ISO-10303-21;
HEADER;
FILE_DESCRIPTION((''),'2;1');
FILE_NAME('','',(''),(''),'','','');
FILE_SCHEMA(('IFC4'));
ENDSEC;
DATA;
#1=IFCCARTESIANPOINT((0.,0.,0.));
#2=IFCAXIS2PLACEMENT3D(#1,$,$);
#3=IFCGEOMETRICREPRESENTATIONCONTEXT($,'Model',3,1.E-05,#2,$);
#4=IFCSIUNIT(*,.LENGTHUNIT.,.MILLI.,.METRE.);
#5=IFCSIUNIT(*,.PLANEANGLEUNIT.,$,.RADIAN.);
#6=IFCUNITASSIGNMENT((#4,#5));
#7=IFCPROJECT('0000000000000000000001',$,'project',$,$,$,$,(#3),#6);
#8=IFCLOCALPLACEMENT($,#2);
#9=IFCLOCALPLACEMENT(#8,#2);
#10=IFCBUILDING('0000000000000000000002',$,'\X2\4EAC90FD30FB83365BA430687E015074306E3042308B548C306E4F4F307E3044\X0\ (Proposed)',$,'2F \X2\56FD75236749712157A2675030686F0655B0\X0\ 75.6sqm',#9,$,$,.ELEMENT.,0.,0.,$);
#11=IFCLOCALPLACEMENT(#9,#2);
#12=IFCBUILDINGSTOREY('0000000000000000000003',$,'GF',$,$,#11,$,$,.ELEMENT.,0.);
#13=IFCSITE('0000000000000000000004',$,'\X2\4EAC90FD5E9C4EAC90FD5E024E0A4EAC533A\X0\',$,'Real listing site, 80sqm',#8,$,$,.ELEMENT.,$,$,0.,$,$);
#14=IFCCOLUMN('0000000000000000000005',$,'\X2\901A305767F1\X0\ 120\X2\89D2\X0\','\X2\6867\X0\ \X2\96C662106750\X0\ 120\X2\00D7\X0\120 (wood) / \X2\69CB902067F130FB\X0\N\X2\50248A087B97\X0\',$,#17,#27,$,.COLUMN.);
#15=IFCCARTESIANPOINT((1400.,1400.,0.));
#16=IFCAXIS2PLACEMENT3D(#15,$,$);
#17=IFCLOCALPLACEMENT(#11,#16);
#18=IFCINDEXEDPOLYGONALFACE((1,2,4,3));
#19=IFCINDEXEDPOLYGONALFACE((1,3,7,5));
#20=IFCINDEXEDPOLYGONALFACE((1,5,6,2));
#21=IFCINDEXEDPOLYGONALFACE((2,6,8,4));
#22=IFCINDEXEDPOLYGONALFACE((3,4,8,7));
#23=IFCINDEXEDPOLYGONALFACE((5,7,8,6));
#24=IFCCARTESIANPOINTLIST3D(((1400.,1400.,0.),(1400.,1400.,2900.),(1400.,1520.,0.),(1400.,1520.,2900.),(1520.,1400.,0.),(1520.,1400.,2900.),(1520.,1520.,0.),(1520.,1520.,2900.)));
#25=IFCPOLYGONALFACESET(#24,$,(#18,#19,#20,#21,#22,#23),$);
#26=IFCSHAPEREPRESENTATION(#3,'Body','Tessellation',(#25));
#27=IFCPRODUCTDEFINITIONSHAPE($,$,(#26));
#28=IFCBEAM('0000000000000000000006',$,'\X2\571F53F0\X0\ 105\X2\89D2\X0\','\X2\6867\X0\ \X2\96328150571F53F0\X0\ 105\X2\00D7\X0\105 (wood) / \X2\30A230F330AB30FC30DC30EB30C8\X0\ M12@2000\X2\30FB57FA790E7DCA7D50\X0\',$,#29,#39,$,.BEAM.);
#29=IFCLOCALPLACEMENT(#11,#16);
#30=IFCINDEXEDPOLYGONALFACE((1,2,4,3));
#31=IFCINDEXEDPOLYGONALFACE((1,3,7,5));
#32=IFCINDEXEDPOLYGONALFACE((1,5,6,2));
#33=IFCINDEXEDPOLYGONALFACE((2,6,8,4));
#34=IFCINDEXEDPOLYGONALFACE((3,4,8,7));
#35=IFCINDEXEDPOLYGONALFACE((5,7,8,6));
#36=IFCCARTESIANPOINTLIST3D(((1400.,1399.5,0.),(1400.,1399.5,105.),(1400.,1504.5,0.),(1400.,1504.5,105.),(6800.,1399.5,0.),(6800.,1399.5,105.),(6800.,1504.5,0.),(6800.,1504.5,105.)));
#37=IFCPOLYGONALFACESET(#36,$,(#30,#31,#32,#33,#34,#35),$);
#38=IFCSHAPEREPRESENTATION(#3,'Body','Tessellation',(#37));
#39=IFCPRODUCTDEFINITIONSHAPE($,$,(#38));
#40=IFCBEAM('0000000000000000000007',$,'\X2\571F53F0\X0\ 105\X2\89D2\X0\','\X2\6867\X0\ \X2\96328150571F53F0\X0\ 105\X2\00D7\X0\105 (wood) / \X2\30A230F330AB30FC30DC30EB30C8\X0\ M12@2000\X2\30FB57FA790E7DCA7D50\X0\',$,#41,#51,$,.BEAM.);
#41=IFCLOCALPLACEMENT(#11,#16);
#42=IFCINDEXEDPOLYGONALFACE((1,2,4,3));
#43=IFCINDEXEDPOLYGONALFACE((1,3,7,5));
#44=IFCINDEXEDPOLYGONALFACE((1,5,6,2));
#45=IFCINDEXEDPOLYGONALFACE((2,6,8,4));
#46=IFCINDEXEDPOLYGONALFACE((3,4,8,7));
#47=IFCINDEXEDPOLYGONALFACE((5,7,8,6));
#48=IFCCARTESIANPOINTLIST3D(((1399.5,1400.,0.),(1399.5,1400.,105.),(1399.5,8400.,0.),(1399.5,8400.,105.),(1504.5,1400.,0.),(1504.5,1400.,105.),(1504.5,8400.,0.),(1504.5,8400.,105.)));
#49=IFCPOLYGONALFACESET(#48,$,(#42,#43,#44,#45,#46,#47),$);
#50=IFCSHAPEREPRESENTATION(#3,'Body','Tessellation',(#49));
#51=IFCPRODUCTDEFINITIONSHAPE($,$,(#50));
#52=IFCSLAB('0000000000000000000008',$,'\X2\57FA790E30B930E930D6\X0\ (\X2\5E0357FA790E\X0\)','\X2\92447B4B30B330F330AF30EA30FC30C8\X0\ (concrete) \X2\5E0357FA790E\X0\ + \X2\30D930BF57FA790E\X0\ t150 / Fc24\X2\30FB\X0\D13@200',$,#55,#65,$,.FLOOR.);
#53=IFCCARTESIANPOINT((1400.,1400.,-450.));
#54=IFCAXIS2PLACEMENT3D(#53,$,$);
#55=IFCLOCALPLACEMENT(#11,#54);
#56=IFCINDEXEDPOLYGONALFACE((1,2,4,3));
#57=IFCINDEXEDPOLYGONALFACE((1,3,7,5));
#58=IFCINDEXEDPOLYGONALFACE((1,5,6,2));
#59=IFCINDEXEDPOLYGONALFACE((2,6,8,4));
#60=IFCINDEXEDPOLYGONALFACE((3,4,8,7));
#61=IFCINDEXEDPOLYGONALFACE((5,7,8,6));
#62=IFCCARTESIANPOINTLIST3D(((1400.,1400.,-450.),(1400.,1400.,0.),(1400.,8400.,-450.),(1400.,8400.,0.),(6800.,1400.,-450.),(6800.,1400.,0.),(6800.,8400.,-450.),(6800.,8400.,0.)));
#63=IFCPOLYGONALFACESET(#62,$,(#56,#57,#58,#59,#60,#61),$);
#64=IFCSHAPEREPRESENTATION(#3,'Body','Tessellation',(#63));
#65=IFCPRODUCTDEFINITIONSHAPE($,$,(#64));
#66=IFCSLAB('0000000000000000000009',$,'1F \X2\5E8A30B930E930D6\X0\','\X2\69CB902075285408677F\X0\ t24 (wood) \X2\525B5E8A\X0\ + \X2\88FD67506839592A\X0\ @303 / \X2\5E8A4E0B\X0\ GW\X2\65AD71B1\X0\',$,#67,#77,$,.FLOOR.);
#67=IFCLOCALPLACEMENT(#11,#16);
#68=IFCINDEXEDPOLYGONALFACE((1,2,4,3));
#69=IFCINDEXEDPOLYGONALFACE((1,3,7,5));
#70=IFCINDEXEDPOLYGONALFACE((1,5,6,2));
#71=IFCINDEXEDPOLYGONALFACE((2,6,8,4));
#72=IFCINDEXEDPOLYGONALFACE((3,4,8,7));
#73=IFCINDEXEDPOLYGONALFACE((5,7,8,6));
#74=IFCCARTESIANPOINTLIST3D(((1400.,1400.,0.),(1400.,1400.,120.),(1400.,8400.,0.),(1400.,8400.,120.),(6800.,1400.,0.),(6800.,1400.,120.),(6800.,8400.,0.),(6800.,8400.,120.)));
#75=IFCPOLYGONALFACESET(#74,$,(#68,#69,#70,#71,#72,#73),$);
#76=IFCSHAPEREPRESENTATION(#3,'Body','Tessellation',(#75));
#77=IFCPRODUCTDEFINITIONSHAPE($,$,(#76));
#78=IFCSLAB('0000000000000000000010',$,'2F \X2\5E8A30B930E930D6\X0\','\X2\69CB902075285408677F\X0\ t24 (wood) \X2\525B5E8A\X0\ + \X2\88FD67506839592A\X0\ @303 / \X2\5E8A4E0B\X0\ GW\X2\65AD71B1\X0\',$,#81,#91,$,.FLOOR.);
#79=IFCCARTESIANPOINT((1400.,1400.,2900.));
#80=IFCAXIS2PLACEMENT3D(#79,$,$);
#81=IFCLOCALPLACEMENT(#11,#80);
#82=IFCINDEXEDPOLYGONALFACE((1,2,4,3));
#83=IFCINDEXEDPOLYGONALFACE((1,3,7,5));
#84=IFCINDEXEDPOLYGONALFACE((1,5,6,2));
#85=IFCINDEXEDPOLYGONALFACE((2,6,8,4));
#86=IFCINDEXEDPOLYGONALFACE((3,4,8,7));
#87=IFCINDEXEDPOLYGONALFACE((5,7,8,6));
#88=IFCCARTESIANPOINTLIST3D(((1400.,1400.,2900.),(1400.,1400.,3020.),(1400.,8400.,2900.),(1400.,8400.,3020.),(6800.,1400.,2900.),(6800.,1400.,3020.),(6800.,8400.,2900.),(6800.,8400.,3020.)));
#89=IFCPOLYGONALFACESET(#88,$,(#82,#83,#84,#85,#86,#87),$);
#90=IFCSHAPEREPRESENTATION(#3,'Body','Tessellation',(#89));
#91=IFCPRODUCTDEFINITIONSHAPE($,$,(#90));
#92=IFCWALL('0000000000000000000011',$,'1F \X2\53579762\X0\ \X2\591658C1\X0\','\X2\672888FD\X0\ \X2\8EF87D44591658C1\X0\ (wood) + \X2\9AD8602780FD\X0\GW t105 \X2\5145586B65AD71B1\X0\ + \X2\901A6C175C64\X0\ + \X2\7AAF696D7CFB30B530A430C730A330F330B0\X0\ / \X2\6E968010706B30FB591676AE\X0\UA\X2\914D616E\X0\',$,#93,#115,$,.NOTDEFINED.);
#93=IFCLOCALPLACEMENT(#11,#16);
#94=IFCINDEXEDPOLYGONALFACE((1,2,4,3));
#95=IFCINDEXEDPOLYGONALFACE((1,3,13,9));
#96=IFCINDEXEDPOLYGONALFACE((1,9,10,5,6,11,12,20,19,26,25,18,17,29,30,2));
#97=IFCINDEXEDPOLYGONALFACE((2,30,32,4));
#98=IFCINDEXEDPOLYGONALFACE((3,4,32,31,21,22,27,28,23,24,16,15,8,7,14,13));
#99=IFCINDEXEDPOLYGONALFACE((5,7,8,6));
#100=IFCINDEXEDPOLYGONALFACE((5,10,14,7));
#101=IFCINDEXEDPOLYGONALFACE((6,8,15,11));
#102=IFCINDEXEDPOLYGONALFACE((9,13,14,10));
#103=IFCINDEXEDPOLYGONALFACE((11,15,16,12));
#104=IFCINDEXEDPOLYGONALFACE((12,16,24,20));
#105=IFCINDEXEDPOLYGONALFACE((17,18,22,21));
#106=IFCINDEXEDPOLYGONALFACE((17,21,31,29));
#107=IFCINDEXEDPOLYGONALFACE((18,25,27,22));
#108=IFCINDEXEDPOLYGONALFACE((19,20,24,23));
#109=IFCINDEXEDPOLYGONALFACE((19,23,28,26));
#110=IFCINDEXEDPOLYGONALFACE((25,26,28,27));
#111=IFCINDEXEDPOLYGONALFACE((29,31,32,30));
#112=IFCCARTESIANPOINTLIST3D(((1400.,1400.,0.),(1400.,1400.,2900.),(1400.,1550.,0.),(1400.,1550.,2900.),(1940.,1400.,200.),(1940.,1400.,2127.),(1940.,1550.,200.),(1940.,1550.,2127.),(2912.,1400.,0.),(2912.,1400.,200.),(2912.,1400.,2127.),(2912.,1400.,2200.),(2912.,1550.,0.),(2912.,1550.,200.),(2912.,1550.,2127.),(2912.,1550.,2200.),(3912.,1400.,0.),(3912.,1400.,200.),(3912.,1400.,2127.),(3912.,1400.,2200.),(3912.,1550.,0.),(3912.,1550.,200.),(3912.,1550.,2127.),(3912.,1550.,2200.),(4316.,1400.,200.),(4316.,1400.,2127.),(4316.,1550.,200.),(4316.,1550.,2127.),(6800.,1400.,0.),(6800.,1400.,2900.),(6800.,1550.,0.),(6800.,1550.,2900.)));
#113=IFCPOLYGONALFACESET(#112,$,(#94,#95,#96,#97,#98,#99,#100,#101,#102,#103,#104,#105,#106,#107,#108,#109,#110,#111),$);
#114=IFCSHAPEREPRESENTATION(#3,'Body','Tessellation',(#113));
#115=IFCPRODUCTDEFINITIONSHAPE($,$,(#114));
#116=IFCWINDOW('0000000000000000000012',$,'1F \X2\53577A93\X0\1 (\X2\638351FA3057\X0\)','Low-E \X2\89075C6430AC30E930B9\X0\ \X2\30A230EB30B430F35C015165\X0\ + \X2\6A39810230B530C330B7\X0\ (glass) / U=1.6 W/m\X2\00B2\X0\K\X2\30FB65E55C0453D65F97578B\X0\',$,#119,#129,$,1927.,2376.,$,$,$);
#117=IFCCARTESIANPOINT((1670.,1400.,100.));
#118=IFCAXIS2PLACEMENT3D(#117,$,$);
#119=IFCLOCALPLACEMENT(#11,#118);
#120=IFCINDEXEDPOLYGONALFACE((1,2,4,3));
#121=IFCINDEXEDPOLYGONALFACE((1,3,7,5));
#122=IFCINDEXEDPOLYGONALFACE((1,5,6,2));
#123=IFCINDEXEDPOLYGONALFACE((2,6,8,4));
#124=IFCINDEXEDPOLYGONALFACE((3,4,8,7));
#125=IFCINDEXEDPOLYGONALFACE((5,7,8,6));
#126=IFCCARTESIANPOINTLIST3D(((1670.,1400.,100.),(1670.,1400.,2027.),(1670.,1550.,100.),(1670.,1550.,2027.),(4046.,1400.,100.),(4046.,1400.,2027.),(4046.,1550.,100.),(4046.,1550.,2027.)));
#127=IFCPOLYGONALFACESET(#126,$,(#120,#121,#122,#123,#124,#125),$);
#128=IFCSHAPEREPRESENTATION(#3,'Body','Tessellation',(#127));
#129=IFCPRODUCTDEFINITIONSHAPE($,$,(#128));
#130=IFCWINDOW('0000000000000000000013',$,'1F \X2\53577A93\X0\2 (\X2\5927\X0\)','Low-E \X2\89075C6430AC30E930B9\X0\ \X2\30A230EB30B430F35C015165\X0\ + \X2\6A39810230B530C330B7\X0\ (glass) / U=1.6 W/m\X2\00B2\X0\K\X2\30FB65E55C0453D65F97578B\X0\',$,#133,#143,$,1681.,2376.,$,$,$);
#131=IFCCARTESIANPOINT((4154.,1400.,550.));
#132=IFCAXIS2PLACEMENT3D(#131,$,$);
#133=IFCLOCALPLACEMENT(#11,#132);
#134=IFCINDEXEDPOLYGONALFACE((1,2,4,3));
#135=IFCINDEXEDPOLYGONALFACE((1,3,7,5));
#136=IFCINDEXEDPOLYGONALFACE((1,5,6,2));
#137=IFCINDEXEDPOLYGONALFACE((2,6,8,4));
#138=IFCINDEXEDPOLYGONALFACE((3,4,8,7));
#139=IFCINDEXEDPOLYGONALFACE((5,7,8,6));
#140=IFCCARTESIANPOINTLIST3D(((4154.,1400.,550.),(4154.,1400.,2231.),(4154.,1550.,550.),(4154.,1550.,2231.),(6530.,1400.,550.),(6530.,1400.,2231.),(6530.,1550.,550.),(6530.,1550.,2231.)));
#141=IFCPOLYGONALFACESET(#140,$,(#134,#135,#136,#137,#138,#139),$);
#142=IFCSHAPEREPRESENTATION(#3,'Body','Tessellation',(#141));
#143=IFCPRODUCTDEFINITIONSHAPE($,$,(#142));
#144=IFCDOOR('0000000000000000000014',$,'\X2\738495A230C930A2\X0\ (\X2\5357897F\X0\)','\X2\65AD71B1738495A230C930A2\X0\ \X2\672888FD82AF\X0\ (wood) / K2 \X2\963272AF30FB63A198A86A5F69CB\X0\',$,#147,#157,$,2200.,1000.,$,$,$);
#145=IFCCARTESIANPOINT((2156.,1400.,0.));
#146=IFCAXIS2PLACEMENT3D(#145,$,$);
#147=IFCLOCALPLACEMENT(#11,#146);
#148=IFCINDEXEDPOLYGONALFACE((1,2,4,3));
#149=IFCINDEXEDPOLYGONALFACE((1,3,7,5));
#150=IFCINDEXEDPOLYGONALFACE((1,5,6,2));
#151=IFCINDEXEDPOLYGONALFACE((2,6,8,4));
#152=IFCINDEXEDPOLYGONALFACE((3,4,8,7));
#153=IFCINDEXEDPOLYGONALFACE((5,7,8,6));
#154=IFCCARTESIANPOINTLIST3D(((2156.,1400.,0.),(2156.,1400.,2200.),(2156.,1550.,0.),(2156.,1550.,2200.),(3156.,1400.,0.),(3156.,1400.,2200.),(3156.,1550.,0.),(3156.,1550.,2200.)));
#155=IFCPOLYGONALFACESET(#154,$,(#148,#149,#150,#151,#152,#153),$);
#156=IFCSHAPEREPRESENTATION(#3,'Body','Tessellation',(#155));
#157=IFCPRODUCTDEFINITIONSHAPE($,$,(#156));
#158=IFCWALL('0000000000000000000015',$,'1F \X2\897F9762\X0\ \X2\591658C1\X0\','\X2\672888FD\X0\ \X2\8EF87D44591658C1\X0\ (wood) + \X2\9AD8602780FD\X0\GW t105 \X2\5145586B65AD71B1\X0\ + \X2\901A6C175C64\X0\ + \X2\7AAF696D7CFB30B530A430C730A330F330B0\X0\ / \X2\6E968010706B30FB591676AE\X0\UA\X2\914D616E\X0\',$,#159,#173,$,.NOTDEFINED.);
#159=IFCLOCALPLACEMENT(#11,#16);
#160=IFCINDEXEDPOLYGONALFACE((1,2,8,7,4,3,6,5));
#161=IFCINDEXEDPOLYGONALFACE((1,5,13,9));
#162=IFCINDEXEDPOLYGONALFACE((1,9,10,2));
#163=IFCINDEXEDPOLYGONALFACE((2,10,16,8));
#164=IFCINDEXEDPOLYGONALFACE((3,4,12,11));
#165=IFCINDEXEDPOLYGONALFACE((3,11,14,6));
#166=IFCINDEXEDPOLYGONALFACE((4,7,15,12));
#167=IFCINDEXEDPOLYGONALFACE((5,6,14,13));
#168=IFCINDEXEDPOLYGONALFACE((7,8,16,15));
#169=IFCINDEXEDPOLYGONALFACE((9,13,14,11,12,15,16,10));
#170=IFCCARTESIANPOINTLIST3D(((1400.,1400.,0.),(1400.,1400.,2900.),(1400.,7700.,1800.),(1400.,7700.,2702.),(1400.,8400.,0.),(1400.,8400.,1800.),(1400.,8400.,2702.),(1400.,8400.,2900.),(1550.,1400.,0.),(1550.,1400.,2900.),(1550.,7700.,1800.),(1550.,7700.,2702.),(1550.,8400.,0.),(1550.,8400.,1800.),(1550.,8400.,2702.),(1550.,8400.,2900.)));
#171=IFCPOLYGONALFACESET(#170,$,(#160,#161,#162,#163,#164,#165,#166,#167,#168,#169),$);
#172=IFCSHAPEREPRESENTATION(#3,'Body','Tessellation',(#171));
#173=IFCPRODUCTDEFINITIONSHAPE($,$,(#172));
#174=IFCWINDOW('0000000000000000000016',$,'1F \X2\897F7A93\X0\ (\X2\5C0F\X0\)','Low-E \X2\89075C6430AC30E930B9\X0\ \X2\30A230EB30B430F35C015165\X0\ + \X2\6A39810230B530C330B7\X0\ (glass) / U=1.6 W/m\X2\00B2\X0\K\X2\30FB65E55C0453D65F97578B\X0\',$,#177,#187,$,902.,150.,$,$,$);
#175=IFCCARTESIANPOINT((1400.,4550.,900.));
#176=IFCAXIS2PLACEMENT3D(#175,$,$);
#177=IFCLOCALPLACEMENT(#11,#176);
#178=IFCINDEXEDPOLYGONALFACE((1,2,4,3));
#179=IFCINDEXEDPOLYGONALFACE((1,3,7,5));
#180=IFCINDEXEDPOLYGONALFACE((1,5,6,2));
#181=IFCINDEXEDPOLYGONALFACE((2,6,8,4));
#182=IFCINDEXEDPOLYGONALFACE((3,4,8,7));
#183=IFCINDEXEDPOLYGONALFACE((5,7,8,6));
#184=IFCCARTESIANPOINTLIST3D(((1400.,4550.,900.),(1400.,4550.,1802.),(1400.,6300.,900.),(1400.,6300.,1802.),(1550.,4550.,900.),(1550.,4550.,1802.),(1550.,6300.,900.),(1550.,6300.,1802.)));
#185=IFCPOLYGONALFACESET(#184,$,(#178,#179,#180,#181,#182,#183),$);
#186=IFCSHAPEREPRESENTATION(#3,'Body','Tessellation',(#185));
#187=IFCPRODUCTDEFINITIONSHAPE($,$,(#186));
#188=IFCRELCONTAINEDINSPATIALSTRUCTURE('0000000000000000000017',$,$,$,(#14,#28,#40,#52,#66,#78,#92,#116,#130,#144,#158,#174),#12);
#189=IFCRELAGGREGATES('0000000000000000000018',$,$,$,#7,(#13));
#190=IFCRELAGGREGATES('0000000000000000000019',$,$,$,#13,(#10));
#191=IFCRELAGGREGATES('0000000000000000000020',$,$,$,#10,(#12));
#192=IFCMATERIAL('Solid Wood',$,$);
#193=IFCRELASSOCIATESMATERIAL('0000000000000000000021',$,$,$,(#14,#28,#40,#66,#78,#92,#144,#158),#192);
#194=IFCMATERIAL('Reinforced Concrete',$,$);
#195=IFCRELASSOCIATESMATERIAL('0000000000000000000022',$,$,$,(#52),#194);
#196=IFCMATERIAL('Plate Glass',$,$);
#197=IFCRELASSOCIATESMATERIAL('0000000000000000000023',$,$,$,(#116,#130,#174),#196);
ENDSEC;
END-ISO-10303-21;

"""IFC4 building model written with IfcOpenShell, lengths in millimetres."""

from ifc_helpers import new_model, si_unit, frame, frame_2d, origin, place, context, project, spatial, rectangle, extrude, material, element, fill, save


model = new_model("IFC4")

# Units and contexts
model_context = context("Model", 3, precision=1e-05, world=origin())
ifc_project = project(units=[si_unit("LENGTHUNIT", "METRE", prefix="MILLI"), si_unit("PLANEANGLEUNIT", "RADIAN")], contexts=[model_context])

# Site, building, storey
site_placement = place(None, origin())
site = spatial("IfcSite", under=ifc_project, at=site_placement, Name="京都府京都市上京区", ObjectType="Real listing site, 80sqm", CompositionType="ELEMENT", RefElevation=0.0)
building_placement = place(site_placement, origin())
building = spatial("IfcBuilding", under=site, at=building_placement, Name="京都・茶室と縁側のある和の住まい (Proposed)", ObjectType="2F 国産杉無垢材と漆喰 75.6sqm", CompositionType="ELEMENT", ElevationOfRefHeight=0.0, ElevationOfTerrain=0.0)
storey_placement = place(building_placement, origin())
storey = spatial("IfcBuildingStorey", under=building, at=storey_placement, Name="GF", CompositionType="ELEMENT", Elevation=0.0)

# Column
ifc_material_1 = material(Name="Solid Wood")
column_placement = place(storey_placement, frame((1400.0, 1400.0, 0.0)))
element("IfcColumn", 1, at=column_placement, inside=storey, material=ifc_material_1, Name="通し柱 120角", Description="桧 集成材 120×120 (wood) / 構造柱・N値計算", PredefinedType="COLUMN", context=model_context, shape_type="SweptSolid", body=[
    extrude(rectangle(XDim=120.0, YDim=120.0, at=frame_2d((60.0, 60.0))), frame((1400.0, 1400.0, 0.0)), (0.0, 0.0, 1.0), 2900.0),
])

# Beams
beam_1_placement = place(storey_placement, frame((1400.0, 1400.0, 0.0)))
element("IfcBeam", 2, at=beam_1_placement, inside=storey, material=ifc_material_1, Name="土台 105角", Description="桧 防腐土台 105×105 (wood) / アンカーボルト M12@2000・基礎緊結", PredefinedType="BEAM", context=model_context, shape_type="SweptSolid", body=[
    extrude(rectangle(XDim=5400.0, YDim=105.0, at=frame_2d((2700.0, 52.0))), frame((1400.0, 1400.0, 0.0)), (0.0, 0.0, 1.0), 105.0),
])
beam_2_placement = place(storey_placement, frame((1400.0, 1400.0, 0.0)))
element("IfcBeam", 3, at=beam_2_placement, inside=storey, material=ifc_material_1, Name="土台 105角", Description="桧 防腐土台 105×105 (wood) / アンカーボルト M12@2000・基礎緊結", PredefinedType="BEAM", context=model_context, shape_type="SweptSolid", body=[
    extrude(rectangle(XDim=105.0, YDim=7000.0, at=frame_2d((52.0, 3500.0))), frame((1400.0, 1400.0, 0.0)), (0.0, 0.0, 1.0), 105.0),
])

# Slabs
ifc_material_2 = material(Name="Reinforced Concrete")
slab_1_placement = place(storey_placement, frame((1400.0, 1400.0, -450.0)))
element("IfcSlab", 4, at=slab_1_placement, inside=storey, material=ifc_material_2, Name="基礎スラブ (布基礎)", Description="鉄筋コンクリート (concrete) 布基礎 + ベタ基礎 t150 / Fc24・D13@200", PredefinedType="FLOOR", context=model_context, shape_type="SweptSolid", body=[
    extrude(rectangle(XDim=5400.0, YDim=7000.0, at=frame_2d((2700.0, 3500.0))), frame((1400.0, 1400.0, -450.0)), (0.0, 0.0, 1.0), 450.0),
])
slab_2_placement = place(storey_placement, frame((1400.0, 1400.0, 0.0)))
element("IfcSlab", 5, at=slab_2_placement, inside=storey, material=ifc_material_1, Name="1F 床スラブ", Description="構造用合板 t24 (wood) 剛床 + 製材根太 @303 / 床下 GW断熱", PredefinedType="FLOOR", context=model_context, shape_type="SweptSolid", body=[
    extrude(rectangle(XDim=5400.0, YDim=7000.0, at=frame_2d((2700.0, 3500.0))), frame((1400.0, 1400.0, 0.0)), (0.0, 0.0, 1.0), 120.0),
])
slab_3_placement = place(storey_placement, frame((1400.0, 1400.0, 2900.0)))
element("IfcSlab", 6, at=slab_3_placement, inside=storey, material=ifc_material_1, Name="2F 床スラブ", Description="構造用合板 t24 (wood) 剛床 + 製材根太 @303 / 床下 GW断熱", PredefinedType="FLOOR", context=model_context, shape_type="SweptSolid", body=[
    extrude(rectangle(XDim=5400.0, YDim=7000.0, at=frame_2d((2700.0, 3500.0))), frame((1400.0, 1400.0, 2900.0)), (0.0, 0.0, 1.0), 120.0),
])

# Wall, openings, windows, door
wall_1_placement = place(storey_placement, frame((1400.0, 1400.0, 0.0)))
wall_1 = element("IfcWall", 7, at=wall_1_placement, inside=storey, material=ifc_material_1, Name="1F 南面 外壁", Description="木製 軸組外壁 (wood) + 高性能GW t105 充填断熱 + 通気層 + 窯業系サイディング / 準耐火・外皮UA配慮", PredefinedType="NOTDEFINED", context=model_context, shape_type="SweptSolid", body=[
    extrude(rectangle(XDim=5400.0, YDim=150.0, at=frame_2d((2700.0, 75.0))), frame((1400.0, 1400.0, 0.0)), (0.0, 0.0, 1.0), 2900.0),
])
opening_1_placement = place(storey_placement, frame((1670.0, 1400.0, 100.0)))
opening_1 = element("IfcOpeningElement", 8, at=opening_1_placement, cuts=wall_1, PredefinedType="NOTDEFINED", context=model_context, shape_type="SweptSolid", body=[
    extrude(rectangle(XDim=2376.0, YDim=150.0, at=frame_2d((1188.0, 75.0))), frame((1670.0, 1400.0, 100.0)), (0.0, 0.0, 1.0), 1927.0),
])
opening_2_placement = place(storey_placement, frame((4154.0, 1400.0, 550.0)))
opening_2 = element("IfcOpeningElement", 9, at=opening_2_placement, cuts=wall_1, PredefinedType="NOTDEFINED", context=model_context, shape_type="SweptSolid", body=[
    extrude(rectangle(XDim=2376.0, YDim=150.0, at=frame_2d((1188.0, 75.0))), frame((4154.0, 1400.0, 550.0)), (0.0, 0.0, 1.0), 1681.0),
])
opening_3_placement = place(storey_placement, frame((2156.0, 1400.0, 0.0)))
opening_3 = element("IfcOpeningElement", 10, at=opening_3_placement, cuts=wall_1, PredefinedType="NOTDEFINED", context=model_context, shape_type="SweptSolid", body=[
    extrude(rectangle(XDim=1000.0, YDim=150.0, at=frame_2d((500.0, 75.0))), frame((2156.0, 1400.0, 0.0)), (0.0, 0.0, 1.0), 2200.0),
])
ifc_material_3 = material(Name="Plate Glass")
window_1_placement = place(storey_placement, frame((1670.0, 1400.0, 100.0)))
window_1 = element("IfcWindow", 11, at=window_1_placement, inside=storey, material=ifc_material_3, Name="1F 南窓1 (掃出し)", Description="Low-E 複層ガラス アルゴン封入 + 樹脂サッシ (glass) / U=1.6 W/m²K・日射取得型", OverallHeight=1927.0, OverallWidth=2376.0, context=model_context, shape_type="SweptSolid", body=[
    extrude(rectangle(XDim=2376.0, YDim=150.0, at=frame_2d((1188.0, 75.0))), frame((1670.0, 1400.0, 100.0)), (0.0, 0.0, 1.0), 1927.0),
])
fill(opening_1, window_1)
window_2_placement = place(storey_placement, frame((4154.0, 1400.0, 550.0)))
window_2 = element("IfcWindow", 12, at=window_2_placement, inside=storey, material=ifc_material_3, Name="1F 南窓2 (大)", Description="Low-E 複層ガラス アルゴン封入 + 樹脂サッシ (glass) / U=1.6 W/m²K・日射取得型", OverallHeight=1681.0, OverallWidth=2376.0, context=model_context, shape_type="SweptSolid", body=[
    extrude(rectangle(XDim=2376.0, YDim=150.0, at=frame_2d((1188.0, 75.0))), frame((4154.0, 1400.0, 550.0)), (0.0, 0.0, 1.0), 1681.0),
])
fill(opening_2, window_2)
door_placement = place(storey_placement, frame((2156.0, 1400.0, 0.0)))
door = element("IfcDoor", 13, at=door_placement, inside=storey, material=ifc_material_1, Name="玄関ドア (南西)", Description="断熱玄関ドア 木製芯 (wood) / K2 防犯・採風機構", OverallHeight=2200.0, OverallWidth=1000.0, context=model_context, shape_type="SweptSolid", body=[
    extrude(rectangle(XDim=1000.0, YDim=150.0, at=frame_2d((500.0, 75.0))), frame((2156.0, 1400.0, 0.0)), (0.0, 0.0, 1.0), 2200.0),
])
fill(opening_3, door)

# Wall, opening, window
wall_2_placement = place(storey_placement, frame((1400.0, 1400.0, 0.0)))
wall_2 = element("IfcWall", 14, at=wall_2_placement, inside=storey, material=ifc_material_1, Name="1F 西面 外壁", Description="木製 軸組外壁 (wood) + 高性能GW t105 充填断熱 + 通気層 + 窯業系サイディング / 準耐火・外皮UA配慮", PredefinedType="NOTDEFINED", context=model_context, shape_type="SweptSolid", body=[
    extrude(rectangle(XDim=150.0, YDim=7000.0, at=frame_2d((75.0, 3500.0))), frame((1400.0, 1400.0, 0.0)), (0.0, 0.0, 1.0), 2900.0),
])
opening_4_placement = place(storey_placement, frame((1400.0, 4550.0, 900.0)))
opening_4 = element("IfcOpeningElement", 15, at=opening_4_placement, cuts=wall_2, PredefinedType="NOTDEFINED", context=model_context, shape_type="SweptSolid", body=[
    extrude(rectangle(XDim=150.0, YDim=1750.0, at=frame_2d((75.0, 875.0))), frame((1400.0, 4550.0, 900.0)), (0.0, 0.0, 1.0), 902.0),
])
window_3_placement = place(storey_placement, frame((1400.0, 4550.0, 900.0)))
window_3 = element("IfcWindow", 16, at=window_3_placement, inside=storey, material=ifc_material_3, Name="1F 西窓 (小)", Description="Low-E 複層ガラス アルゴン封入 + 樹脂サッシ (glass) / U=1.6 W/m²K・日射取得型", OverallHeight=902.0, OverallWidth=150.0, context=model_context, shape_type="SweptSolid", body=[
    extrude(rectangle(XDim=150.0, YDim=1750.0, at=frame_2d((75.0, 875.0))), frame((1400.0, 4550.0, 900.0)), (0.0, 0.0, 1.0), 902.0),
])
fill(opening_4, window_3)

save(model, "model.ifc")
